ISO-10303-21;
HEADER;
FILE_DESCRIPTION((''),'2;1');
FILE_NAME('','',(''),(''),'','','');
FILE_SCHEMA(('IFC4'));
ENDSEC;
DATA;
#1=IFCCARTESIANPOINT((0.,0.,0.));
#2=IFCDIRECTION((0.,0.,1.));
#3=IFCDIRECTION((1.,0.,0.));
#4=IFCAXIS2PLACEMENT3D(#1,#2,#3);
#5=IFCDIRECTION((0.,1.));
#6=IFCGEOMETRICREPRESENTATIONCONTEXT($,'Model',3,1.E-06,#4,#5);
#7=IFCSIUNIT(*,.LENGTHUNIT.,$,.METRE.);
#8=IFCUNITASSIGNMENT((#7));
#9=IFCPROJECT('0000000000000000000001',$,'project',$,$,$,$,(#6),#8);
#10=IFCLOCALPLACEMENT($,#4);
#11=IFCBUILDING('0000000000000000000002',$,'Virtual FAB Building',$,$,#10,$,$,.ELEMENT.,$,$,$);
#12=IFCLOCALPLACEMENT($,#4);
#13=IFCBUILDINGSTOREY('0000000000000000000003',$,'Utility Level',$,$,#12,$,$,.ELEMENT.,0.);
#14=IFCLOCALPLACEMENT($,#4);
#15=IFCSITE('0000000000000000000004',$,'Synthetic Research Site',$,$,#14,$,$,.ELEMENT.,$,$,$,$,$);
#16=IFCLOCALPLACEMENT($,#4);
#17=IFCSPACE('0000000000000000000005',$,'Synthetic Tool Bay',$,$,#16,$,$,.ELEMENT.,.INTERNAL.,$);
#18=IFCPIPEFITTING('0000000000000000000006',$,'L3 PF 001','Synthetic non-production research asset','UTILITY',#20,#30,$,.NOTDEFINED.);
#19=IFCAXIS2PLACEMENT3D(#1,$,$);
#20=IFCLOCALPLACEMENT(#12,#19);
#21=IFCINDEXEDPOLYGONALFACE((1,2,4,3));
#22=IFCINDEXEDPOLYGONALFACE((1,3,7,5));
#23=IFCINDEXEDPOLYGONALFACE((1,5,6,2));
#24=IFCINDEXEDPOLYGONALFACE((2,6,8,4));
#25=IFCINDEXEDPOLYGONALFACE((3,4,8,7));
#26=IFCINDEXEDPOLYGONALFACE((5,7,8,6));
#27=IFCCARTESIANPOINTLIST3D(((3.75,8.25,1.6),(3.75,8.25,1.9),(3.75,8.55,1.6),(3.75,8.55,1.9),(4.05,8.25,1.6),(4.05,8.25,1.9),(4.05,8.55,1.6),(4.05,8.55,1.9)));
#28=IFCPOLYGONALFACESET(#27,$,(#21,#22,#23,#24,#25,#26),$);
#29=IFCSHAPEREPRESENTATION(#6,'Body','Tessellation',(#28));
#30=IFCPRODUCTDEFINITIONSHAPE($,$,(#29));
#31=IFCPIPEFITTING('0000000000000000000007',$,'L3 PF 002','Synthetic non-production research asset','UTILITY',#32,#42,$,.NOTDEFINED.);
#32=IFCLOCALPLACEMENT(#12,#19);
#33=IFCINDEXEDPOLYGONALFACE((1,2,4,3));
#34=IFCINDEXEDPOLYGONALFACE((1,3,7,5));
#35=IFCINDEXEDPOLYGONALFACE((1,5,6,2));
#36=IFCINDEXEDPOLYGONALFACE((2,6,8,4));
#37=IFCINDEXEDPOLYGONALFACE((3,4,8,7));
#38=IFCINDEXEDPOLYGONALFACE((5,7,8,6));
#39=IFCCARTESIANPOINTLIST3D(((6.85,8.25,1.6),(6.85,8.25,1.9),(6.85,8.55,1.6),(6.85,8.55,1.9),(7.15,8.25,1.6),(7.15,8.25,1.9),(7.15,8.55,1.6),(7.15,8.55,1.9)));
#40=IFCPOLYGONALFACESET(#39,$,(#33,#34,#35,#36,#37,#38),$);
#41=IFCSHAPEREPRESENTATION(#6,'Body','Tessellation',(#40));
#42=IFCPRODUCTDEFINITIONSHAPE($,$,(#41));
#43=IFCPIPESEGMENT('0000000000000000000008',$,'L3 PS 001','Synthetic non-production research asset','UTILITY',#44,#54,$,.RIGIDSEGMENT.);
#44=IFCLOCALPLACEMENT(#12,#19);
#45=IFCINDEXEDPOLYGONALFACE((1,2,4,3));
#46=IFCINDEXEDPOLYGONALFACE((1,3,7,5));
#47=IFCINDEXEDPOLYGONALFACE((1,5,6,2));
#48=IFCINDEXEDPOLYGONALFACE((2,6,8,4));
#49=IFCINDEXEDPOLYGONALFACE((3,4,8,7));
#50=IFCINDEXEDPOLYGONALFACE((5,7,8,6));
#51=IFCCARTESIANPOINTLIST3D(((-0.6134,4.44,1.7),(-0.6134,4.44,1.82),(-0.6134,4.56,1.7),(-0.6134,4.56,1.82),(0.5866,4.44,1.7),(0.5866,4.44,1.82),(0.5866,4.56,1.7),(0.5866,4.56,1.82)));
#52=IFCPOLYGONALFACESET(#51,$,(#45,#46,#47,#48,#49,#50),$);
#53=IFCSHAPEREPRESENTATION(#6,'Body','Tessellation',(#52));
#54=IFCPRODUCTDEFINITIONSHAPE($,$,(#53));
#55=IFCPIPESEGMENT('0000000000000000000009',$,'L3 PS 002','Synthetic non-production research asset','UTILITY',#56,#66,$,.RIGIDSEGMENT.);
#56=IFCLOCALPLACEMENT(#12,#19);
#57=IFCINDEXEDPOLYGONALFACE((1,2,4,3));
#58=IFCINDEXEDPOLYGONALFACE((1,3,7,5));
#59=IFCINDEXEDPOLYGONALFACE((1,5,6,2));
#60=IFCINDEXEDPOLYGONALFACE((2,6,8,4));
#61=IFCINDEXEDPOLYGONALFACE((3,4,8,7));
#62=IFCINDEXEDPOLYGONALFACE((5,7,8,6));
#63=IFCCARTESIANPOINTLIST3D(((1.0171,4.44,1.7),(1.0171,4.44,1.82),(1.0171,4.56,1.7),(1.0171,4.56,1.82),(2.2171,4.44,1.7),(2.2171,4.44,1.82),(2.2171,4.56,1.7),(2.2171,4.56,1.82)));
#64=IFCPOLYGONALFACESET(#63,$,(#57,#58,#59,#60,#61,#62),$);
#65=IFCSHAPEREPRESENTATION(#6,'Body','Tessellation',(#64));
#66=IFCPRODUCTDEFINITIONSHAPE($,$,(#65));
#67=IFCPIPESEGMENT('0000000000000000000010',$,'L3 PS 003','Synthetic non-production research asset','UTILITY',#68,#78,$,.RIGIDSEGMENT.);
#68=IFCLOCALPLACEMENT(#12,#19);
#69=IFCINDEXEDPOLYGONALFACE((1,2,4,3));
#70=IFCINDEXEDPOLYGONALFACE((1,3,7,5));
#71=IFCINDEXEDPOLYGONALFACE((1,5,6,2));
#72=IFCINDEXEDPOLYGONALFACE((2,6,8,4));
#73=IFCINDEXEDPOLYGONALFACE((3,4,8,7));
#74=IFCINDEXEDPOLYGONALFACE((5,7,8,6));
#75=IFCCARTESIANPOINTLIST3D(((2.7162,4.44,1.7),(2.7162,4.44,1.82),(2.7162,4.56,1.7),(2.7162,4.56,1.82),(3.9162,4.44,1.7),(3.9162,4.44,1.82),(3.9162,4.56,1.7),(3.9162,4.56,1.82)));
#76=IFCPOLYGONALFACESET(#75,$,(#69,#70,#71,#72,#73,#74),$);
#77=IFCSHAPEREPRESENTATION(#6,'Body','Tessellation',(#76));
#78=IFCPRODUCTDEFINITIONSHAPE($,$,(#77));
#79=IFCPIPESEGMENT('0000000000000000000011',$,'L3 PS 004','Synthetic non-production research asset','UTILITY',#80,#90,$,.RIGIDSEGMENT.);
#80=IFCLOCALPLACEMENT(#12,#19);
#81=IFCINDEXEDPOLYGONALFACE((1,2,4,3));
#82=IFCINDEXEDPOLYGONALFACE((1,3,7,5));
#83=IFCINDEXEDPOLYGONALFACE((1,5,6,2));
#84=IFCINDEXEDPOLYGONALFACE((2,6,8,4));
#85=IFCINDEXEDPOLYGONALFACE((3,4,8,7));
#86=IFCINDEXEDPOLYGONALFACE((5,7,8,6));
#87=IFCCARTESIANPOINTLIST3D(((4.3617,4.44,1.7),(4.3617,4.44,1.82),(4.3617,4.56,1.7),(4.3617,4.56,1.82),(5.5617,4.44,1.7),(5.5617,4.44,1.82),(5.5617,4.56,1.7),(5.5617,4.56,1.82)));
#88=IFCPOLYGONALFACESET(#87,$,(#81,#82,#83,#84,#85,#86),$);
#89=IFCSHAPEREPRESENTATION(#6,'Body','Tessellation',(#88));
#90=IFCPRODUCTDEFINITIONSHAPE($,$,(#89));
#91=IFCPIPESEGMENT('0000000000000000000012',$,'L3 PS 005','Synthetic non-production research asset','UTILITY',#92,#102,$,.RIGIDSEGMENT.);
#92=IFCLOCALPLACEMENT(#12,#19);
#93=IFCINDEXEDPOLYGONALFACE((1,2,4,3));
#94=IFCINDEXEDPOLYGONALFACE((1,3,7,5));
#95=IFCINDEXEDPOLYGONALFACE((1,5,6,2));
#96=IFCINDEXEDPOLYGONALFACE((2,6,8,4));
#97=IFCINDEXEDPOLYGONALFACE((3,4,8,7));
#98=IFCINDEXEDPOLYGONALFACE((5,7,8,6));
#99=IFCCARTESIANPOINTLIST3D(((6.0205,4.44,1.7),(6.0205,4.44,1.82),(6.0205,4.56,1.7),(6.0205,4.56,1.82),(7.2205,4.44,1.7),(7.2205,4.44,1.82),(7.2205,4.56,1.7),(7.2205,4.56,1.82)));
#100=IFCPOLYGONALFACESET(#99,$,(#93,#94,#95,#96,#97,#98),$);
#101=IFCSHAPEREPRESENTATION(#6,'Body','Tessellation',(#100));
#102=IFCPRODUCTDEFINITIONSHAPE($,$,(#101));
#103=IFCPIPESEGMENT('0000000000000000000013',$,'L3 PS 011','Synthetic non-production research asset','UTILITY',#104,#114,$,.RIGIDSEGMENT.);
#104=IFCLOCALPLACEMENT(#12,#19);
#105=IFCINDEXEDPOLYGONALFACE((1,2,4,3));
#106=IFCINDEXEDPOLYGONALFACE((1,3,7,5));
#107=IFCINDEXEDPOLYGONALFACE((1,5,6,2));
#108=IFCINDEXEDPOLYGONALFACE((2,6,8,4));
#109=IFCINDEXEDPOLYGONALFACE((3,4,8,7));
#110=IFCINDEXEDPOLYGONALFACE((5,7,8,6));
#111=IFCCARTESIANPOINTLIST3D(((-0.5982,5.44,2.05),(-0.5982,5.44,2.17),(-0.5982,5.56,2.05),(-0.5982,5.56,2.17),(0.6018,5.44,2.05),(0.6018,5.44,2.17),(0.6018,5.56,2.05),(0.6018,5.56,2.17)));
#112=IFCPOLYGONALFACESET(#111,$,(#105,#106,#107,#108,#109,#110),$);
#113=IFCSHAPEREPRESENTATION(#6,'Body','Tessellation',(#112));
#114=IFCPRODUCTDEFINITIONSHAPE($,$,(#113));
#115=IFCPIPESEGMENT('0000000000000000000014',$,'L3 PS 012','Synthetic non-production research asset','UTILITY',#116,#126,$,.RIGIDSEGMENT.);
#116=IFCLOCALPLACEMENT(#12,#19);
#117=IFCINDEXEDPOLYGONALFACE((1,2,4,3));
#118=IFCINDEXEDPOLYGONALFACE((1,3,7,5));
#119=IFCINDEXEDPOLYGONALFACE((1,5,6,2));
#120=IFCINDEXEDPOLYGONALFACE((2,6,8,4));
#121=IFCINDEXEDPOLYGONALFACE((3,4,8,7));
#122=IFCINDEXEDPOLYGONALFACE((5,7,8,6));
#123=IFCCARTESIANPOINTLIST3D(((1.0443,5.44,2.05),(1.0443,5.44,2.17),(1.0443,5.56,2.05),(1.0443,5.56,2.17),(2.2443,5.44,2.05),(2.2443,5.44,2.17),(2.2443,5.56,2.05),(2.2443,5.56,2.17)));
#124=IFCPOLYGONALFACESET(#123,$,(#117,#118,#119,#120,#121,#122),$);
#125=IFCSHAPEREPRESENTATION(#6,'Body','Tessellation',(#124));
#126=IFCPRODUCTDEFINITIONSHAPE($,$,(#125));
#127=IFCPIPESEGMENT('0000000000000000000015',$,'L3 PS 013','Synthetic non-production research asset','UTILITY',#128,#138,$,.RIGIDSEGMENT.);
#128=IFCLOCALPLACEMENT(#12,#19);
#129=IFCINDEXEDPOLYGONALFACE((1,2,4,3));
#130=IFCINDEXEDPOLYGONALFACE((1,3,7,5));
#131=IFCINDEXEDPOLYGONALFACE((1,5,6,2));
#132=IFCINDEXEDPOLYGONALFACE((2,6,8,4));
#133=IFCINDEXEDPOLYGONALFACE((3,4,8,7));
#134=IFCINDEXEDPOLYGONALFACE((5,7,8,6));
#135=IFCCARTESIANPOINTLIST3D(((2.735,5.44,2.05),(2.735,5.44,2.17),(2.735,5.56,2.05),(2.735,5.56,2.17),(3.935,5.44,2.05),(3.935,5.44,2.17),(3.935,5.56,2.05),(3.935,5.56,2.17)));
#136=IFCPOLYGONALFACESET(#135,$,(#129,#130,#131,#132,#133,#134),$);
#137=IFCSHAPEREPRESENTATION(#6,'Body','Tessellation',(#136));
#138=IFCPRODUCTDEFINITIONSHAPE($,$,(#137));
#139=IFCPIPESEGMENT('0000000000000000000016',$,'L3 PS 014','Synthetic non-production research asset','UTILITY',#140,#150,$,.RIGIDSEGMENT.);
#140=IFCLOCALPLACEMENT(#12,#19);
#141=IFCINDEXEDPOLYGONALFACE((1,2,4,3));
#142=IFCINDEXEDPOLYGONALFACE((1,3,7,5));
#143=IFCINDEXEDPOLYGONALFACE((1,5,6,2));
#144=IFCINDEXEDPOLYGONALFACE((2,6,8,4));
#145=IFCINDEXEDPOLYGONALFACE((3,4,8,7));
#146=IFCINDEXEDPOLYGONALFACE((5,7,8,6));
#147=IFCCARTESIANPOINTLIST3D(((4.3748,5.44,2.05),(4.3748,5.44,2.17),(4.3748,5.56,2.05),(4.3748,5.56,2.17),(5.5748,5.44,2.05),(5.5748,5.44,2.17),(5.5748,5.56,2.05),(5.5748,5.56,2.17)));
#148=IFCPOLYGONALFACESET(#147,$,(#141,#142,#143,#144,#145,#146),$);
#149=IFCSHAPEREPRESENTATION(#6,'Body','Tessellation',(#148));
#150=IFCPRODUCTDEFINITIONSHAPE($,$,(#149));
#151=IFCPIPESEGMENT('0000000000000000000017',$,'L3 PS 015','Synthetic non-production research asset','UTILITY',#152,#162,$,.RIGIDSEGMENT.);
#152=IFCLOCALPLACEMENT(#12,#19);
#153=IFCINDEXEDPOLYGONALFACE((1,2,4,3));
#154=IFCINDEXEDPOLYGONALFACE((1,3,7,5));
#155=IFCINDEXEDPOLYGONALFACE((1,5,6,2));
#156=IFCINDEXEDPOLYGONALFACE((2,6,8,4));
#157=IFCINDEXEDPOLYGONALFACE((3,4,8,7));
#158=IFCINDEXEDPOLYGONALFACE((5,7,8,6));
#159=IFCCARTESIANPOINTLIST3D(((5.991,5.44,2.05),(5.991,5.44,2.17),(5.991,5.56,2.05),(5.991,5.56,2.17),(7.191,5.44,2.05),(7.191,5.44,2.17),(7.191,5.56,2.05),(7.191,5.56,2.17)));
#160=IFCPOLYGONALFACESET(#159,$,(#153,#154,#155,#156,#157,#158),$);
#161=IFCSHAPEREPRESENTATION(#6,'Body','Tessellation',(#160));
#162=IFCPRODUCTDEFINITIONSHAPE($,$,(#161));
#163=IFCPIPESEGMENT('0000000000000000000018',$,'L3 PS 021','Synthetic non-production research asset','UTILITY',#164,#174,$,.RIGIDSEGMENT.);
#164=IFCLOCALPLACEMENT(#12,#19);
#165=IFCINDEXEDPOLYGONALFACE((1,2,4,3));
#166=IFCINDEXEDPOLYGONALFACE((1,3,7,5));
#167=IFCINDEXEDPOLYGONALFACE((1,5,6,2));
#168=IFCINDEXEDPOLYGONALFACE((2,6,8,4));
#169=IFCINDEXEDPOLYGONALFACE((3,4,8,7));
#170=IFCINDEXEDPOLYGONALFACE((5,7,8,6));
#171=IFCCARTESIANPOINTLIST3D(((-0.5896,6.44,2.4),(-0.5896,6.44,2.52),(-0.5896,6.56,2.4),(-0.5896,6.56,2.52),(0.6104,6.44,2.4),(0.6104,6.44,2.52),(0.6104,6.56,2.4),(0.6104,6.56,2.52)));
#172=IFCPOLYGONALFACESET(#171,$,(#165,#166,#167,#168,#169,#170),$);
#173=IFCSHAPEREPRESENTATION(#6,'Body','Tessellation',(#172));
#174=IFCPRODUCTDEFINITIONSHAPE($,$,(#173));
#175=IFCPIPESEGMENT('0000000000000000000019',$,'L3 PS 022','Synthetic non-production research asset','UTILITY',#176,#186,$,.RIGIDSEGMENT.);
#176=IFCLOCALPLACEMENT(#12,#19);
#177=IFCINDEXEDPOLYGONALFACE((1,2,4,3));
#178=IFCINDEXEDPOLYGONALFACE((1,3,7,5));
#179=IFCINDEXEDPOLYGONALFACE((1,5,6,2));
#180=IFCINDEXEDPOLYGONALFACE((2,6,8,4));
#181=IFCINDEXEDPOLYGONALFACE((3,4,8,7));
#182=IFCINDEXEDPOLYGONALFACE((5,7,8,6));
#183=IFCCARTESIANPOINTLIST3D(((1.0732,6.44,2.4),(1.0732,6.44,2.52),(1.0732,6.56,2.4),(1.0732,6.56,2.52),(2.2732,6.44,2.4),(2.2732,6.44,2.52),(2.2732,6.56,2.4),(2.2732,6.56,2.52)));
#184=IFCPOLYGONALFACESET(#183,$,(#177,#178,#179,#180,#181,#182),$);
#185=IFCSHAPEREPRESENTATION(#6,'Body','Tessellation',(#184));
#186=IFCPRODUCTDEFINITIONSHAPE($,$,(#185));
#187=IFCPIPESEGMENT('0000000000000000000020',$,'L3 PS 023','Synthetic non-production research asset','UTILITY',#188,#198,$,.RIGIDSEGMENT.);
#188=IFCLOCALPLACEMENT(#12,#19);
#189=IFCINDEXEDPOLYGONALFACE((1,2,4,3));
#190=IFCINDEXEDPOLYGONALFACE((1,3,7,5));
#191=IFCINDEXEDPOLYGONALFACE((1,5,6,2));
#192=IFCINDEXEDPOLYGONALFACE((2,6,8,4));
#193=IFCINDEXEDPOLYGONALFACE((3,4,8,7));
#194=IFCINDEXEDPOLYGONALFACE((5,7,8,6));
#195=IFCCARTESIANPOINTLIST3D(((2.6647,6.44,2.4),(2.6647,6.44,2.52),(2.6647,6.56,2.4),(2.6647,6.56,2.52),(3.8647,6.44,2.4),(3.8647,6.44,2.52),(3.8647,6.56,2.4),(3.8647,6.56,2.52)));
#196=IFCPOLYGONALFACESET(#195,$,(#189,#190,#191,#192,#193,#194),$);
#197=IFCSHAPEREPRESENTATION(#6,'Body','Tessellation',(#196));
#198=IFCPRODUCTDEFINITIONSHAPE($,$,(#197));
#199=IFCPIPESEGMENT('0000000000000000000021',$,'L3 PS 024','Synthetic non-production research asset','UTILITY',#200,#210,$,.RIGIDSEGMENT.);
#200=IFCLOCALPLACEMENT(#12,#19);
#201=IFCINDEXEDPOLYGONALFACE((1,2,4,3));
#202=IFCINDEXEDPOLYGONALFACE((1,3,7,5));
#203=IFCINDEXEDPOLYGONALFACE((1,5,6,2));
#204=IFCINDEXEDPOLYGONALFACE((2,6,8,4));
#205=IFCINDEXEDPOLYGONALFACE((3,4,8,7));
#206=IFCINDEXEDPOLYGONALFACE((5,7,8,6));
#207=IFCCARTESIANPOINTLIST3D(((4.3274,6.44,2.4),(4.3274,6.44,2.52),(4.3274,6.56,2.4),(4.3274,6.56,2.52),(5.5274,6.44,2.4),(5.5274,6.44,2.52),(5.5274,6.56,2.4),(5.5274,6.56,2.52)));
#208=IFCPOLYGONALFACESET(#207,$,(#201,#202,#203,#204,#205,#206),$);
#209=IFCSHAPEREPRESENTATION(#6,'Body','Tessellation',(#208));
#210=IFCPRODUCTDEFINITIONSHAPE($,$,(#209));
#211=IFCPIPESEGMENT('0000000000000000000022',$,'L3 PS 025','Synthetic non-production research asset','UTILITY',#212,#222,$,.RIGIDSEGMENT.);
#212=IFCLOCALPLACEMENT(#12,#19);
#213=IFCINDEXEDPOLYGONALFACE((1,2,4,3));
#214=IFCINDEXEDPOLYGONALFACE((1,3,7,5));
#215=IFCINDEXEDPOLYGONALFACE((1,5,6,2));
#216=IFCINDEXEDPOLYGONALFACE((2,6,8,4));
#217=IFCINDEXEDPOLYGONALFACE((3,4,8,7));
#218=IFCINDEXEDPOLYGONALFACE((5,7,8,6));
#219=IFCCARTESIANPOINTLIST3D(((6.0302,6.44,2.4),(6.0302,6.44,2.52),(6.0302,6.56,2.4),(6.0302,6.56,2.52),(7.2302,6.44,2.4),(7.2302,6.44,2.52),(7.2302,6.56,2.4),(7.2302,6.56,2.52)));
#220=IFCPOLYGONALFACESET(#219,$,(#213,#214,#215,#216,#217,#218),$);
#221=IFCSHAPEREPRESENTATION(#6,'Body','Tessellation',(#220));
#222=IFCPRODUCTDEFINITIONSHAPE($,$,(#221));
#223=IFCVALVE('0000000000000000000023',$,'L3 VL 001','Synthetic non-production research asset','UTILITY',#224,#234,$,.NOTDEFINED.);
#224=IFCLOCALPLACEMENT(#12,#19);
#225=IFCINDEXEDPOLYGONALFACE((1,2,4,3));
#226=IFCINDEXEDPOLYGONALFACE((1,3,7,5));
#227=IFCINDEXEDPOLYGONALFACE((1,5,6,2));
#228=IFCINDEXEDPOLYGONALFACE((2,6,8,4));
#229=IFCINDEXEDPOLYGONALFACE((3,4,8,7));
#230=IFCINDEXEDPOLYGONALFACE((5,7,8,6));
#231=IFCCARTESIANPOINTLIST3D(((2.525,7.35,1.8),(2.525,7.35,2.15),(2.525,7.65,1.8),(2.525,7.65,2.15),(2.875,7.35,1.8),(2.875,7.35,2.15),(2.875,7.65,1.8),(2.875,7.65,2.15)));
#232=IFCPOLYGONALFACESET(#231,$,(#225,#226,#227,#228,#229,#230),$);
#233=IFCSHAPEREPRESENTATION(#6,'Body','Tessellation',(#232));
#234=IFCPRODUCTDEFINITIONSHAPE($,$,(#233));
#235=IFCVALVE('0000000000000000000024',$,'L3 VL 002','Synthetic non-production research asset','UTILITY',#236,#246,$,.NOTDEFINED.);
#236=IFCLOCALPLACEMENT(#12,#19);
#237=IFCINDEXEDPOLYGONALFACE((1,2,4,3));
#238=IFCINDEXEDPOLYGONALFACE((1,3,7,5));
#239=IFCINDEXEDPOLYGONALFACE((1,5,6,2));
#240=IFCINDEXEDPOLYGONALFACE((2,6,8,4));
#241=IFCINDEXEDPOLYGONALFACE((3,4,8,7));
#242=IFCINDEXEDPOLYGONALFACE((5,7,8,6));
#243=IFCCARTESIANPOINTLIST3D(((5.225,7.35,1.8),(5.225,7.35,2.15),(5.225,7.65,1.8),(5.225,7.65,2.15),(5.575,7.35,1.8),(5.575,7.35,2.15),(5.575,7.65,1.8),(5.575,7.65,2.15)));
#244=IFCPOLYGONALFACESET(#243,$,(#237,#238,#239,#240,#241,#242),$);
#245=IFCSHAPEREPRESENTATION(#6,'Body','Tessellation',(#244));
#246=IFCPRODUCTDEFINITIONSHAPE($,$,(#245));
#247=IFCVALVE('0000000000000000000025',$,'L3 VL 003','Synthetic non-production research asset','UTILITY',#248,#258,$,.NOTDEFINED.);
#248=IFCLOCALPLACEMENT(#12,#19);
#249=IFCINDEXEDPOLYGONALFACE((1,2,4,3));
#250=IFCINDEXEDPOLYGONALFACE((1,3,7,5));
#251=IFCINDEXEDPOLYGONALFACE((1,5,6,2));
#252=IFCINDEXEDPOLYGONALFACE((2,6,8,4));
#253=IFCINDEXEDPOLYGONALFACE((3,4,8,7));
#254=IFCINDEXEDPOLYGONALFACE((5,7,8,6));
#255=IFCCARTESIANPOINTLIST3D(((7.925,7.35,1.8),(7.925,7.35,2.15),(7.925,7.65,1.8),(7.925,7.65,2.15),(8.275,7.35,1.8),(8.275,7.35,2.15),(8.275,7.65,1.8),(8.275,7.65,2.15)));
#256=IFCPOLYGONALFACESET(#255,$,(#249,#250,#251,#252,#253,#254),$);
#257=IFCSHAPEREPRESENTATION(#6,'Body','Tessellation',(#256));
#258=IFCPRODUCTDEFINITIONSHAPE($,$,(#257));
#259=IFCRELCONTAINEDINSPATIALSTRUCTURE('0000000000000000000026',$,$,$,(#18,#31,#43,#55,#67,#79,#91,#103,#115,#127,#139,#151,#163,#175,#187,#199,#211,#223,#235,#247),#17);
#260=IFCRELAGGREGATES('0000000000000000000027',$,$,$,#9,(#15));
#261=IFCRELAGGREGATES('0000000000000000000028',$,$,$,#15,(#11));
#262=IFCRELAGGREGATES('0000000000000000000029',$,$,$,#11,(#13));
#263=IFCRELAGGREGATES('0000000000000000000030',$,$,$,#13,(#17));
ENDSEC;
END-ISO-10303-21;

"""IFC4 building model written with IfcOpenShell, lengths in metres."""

from ifc_helpers import new_model, si_unit, direction, frame, origin_with_axes, origin_2d_with_axis, place, context, project, spatial, rectangle, extrude, element, save


model = new_model("IFC4")

# Units and contexts
model_context = context("Model", 3, precision=1e-06, world=origin_with_axes(), true_north=direction((0.0, 1.0)))
ifc_project = project(units=[si_unit("LENGTHUNIT", "METRE")], contexts=[model_context])

# Site, building, storey, space
site_placement = place(None, origin_with_axes())
site = spatial("IfcSite", under=ifc_project, at=site_placement, Name="Synthetic Research Site", CompositionType="ELEMENT")
building_placement = place(None, origin_with_axes())
building = spatial("IfcBuilding", under=site, at=building_placement, Name="Virtual FAB Building", CompositionType="ELEMENT")
storey_placement = place(None, origin_with_axes())
storey = spatial("IfcBuildingStorey", under=building, at=storey_placement, Name="Utility Level", CompositionType="ELEMENT", Elevation=0.0)
space_placement = place(None, origin_with_axes())
space = spatial("IfcSpace", under=storey, at=space_placement, Name="Synthetic Tool Bay", CompositionType="ELEMENT", PredefinedType="INTERNAL")

# Pipe fittings
for number, where, z_axis, x_axis, name in (
    (1, (3.9, 8.4, 1.6), (0.0, 0.0, 1.0), (1.0, 0.0, 0.0), "L3 PF 001"),
    (2, (7.0, 8.4, 1.6), (0.0, 0.0, 1.0), (1.0, 0.0, 0.0), "L3 PF 002"),
):
    element("IfcPipeFitting", number, at=place(None, frame(where, z_axis=z_axis, x_axis=x_axis)), inside=space, Name=name, Description="Synthetic non-production research asset", ObjectType="UTILITY", PredefinedType="NOTDEFINED", context=model_context, shape_type="SweptSolid", body=[
        extrude(rectangle(XDim=0.3, YDim=0.3, at=origin_2d_with_axis()), origin_with_axes(), (0.0, 0.0, 1.0), 0.3),
    ])

# Pipe segments
for number, where, z_axis, x_axis, name in (
    (3, (-0.0134, 4.5, 1.7), (0.0, 0.0, 1.0), (1.0, 0.0, 0.0), "L3 PS 001"),
    (4, (1.6171, 4.5, 1.7), (0.0, 0.0, 1.0), (1.0, 0.0, 0.0), "L3 PS 002"),
    (5, (3.3162, 4.5, 1.7), (0.0, 0.0, 1.0), (1.0, 0.0, 0.0), "L3 PS 003"),
    (6, (4.9617, 4.5, 1.7), (0.0, 0.0, 1.0), (1.0, 0.0, 0.0), "L3 PS 004"),
    (7, (6.6205, 4.5, 1.7), (0.0, 0.0, 1.0), (1.0, 0.0, 0.0), "L3 PS 005"),
    (8, (0.0018, 5.5, 2.05), (0.0, 0.0, 1.0), (1.0, 0.0, 0.0), "L3 PS 011"),
    (9, (1.6443, 5.5, 2.05), (0.0, 0.0, 1.0), (1.0, 0.0, 0.0), "L3 PS 012"),
    (10, (3.335, 5.5, 2.05), (0.0, 0.0, 1.0), (1.0, 0.0, 0.0), "L3 PS 013"),
    (11, (4.9748, 5.5, 2.05), (0.0, 0.0, 1.0), (1.0, 0.0, 0.0), "L3 PS 014"),
    (12, (6.591, 5.5, 2.05), (0.0, 0.0, 1.0), (1.0, 0.0, 0.0), "L3 PS 015"),
    (13, (0.0104, 6.5, 2.4), (0.0, 0.0, 1.0), (1.0, 0.0, 0.0), "L3 PS 021"),
    (14, (1.6732, 6.5, 2.4), (0.0, 0.0, 1.0), (1.0, 0.0, 0.0), "L3 PS 022"),
    (15, (3.2647, 6.5, 2.4), (0.0, 0.0, 1.0), (1.0, 0.0, 0.0), "L3 PS 023"),
    (16, (4.9274, 6.5, 2.4), (0.0, 0.0, 1.0), (1.0, 0.0, 0.0), "L3 PS 024"),
    (17, (6.6302, 6.5, 2.4), (0.0, 0.0, 1.0), (1.0, 0.0, 0.0), "L3 PS 025"),
):
    element("IfcPipeSegment", number, at=place(None, frame(where, z_axis=z_axis, x_axis=x_axis)), inside=space, Name=name, Description="Synthetic non-production research asset", ObjectType="UTILITY", PredefinedType="RIGIDSEGMENT", context=model_context, shape_type="SweptSolid", body=[
        extrude(rectangle(XDim=1.2, YDim=0.12, at=origin_2d_with_axis()), origin_with_axes(), (0.0, 0.0, 1.0), 0.12),
    ])

# Valves
for number, where, z_axis, x_axis, name in (
    (18, (2.7, 7.5, 1.8), (0.0, 0.0, 1.0), (1.0, 0.0, 0.0), "L3 VL 001"),
    (19, (5.4, 7.5, 1.8), (0.0, 0.0, 1.0), (1.0, 0.0, 0.0), "L3 VL 002"),
    (20, (8.1, 7.5, 1.8), (0.0, 0.0, 1.0), (1.0, 0.0, 0.0), "L3 VL 003"),
):
    element("IfcValve", number, at=place(None, frame(where, z_axis=z_axis, x_axis=x_axis)), inside=space, Name=name, Description="Synthetic non-production research asset", ObjectType="UTILITY", PredefinedType="NOTDEFINED", context=model_context, shape_type="SweptSolid", body=[
        extrude(rectangle(XDim=0.35, YDim=0.3, at=origin_2d_with_axis()), origin_with_axes(), (0.0, 0.0, 1.0), 0.35),
    ])

save(model, "model.ifc")
